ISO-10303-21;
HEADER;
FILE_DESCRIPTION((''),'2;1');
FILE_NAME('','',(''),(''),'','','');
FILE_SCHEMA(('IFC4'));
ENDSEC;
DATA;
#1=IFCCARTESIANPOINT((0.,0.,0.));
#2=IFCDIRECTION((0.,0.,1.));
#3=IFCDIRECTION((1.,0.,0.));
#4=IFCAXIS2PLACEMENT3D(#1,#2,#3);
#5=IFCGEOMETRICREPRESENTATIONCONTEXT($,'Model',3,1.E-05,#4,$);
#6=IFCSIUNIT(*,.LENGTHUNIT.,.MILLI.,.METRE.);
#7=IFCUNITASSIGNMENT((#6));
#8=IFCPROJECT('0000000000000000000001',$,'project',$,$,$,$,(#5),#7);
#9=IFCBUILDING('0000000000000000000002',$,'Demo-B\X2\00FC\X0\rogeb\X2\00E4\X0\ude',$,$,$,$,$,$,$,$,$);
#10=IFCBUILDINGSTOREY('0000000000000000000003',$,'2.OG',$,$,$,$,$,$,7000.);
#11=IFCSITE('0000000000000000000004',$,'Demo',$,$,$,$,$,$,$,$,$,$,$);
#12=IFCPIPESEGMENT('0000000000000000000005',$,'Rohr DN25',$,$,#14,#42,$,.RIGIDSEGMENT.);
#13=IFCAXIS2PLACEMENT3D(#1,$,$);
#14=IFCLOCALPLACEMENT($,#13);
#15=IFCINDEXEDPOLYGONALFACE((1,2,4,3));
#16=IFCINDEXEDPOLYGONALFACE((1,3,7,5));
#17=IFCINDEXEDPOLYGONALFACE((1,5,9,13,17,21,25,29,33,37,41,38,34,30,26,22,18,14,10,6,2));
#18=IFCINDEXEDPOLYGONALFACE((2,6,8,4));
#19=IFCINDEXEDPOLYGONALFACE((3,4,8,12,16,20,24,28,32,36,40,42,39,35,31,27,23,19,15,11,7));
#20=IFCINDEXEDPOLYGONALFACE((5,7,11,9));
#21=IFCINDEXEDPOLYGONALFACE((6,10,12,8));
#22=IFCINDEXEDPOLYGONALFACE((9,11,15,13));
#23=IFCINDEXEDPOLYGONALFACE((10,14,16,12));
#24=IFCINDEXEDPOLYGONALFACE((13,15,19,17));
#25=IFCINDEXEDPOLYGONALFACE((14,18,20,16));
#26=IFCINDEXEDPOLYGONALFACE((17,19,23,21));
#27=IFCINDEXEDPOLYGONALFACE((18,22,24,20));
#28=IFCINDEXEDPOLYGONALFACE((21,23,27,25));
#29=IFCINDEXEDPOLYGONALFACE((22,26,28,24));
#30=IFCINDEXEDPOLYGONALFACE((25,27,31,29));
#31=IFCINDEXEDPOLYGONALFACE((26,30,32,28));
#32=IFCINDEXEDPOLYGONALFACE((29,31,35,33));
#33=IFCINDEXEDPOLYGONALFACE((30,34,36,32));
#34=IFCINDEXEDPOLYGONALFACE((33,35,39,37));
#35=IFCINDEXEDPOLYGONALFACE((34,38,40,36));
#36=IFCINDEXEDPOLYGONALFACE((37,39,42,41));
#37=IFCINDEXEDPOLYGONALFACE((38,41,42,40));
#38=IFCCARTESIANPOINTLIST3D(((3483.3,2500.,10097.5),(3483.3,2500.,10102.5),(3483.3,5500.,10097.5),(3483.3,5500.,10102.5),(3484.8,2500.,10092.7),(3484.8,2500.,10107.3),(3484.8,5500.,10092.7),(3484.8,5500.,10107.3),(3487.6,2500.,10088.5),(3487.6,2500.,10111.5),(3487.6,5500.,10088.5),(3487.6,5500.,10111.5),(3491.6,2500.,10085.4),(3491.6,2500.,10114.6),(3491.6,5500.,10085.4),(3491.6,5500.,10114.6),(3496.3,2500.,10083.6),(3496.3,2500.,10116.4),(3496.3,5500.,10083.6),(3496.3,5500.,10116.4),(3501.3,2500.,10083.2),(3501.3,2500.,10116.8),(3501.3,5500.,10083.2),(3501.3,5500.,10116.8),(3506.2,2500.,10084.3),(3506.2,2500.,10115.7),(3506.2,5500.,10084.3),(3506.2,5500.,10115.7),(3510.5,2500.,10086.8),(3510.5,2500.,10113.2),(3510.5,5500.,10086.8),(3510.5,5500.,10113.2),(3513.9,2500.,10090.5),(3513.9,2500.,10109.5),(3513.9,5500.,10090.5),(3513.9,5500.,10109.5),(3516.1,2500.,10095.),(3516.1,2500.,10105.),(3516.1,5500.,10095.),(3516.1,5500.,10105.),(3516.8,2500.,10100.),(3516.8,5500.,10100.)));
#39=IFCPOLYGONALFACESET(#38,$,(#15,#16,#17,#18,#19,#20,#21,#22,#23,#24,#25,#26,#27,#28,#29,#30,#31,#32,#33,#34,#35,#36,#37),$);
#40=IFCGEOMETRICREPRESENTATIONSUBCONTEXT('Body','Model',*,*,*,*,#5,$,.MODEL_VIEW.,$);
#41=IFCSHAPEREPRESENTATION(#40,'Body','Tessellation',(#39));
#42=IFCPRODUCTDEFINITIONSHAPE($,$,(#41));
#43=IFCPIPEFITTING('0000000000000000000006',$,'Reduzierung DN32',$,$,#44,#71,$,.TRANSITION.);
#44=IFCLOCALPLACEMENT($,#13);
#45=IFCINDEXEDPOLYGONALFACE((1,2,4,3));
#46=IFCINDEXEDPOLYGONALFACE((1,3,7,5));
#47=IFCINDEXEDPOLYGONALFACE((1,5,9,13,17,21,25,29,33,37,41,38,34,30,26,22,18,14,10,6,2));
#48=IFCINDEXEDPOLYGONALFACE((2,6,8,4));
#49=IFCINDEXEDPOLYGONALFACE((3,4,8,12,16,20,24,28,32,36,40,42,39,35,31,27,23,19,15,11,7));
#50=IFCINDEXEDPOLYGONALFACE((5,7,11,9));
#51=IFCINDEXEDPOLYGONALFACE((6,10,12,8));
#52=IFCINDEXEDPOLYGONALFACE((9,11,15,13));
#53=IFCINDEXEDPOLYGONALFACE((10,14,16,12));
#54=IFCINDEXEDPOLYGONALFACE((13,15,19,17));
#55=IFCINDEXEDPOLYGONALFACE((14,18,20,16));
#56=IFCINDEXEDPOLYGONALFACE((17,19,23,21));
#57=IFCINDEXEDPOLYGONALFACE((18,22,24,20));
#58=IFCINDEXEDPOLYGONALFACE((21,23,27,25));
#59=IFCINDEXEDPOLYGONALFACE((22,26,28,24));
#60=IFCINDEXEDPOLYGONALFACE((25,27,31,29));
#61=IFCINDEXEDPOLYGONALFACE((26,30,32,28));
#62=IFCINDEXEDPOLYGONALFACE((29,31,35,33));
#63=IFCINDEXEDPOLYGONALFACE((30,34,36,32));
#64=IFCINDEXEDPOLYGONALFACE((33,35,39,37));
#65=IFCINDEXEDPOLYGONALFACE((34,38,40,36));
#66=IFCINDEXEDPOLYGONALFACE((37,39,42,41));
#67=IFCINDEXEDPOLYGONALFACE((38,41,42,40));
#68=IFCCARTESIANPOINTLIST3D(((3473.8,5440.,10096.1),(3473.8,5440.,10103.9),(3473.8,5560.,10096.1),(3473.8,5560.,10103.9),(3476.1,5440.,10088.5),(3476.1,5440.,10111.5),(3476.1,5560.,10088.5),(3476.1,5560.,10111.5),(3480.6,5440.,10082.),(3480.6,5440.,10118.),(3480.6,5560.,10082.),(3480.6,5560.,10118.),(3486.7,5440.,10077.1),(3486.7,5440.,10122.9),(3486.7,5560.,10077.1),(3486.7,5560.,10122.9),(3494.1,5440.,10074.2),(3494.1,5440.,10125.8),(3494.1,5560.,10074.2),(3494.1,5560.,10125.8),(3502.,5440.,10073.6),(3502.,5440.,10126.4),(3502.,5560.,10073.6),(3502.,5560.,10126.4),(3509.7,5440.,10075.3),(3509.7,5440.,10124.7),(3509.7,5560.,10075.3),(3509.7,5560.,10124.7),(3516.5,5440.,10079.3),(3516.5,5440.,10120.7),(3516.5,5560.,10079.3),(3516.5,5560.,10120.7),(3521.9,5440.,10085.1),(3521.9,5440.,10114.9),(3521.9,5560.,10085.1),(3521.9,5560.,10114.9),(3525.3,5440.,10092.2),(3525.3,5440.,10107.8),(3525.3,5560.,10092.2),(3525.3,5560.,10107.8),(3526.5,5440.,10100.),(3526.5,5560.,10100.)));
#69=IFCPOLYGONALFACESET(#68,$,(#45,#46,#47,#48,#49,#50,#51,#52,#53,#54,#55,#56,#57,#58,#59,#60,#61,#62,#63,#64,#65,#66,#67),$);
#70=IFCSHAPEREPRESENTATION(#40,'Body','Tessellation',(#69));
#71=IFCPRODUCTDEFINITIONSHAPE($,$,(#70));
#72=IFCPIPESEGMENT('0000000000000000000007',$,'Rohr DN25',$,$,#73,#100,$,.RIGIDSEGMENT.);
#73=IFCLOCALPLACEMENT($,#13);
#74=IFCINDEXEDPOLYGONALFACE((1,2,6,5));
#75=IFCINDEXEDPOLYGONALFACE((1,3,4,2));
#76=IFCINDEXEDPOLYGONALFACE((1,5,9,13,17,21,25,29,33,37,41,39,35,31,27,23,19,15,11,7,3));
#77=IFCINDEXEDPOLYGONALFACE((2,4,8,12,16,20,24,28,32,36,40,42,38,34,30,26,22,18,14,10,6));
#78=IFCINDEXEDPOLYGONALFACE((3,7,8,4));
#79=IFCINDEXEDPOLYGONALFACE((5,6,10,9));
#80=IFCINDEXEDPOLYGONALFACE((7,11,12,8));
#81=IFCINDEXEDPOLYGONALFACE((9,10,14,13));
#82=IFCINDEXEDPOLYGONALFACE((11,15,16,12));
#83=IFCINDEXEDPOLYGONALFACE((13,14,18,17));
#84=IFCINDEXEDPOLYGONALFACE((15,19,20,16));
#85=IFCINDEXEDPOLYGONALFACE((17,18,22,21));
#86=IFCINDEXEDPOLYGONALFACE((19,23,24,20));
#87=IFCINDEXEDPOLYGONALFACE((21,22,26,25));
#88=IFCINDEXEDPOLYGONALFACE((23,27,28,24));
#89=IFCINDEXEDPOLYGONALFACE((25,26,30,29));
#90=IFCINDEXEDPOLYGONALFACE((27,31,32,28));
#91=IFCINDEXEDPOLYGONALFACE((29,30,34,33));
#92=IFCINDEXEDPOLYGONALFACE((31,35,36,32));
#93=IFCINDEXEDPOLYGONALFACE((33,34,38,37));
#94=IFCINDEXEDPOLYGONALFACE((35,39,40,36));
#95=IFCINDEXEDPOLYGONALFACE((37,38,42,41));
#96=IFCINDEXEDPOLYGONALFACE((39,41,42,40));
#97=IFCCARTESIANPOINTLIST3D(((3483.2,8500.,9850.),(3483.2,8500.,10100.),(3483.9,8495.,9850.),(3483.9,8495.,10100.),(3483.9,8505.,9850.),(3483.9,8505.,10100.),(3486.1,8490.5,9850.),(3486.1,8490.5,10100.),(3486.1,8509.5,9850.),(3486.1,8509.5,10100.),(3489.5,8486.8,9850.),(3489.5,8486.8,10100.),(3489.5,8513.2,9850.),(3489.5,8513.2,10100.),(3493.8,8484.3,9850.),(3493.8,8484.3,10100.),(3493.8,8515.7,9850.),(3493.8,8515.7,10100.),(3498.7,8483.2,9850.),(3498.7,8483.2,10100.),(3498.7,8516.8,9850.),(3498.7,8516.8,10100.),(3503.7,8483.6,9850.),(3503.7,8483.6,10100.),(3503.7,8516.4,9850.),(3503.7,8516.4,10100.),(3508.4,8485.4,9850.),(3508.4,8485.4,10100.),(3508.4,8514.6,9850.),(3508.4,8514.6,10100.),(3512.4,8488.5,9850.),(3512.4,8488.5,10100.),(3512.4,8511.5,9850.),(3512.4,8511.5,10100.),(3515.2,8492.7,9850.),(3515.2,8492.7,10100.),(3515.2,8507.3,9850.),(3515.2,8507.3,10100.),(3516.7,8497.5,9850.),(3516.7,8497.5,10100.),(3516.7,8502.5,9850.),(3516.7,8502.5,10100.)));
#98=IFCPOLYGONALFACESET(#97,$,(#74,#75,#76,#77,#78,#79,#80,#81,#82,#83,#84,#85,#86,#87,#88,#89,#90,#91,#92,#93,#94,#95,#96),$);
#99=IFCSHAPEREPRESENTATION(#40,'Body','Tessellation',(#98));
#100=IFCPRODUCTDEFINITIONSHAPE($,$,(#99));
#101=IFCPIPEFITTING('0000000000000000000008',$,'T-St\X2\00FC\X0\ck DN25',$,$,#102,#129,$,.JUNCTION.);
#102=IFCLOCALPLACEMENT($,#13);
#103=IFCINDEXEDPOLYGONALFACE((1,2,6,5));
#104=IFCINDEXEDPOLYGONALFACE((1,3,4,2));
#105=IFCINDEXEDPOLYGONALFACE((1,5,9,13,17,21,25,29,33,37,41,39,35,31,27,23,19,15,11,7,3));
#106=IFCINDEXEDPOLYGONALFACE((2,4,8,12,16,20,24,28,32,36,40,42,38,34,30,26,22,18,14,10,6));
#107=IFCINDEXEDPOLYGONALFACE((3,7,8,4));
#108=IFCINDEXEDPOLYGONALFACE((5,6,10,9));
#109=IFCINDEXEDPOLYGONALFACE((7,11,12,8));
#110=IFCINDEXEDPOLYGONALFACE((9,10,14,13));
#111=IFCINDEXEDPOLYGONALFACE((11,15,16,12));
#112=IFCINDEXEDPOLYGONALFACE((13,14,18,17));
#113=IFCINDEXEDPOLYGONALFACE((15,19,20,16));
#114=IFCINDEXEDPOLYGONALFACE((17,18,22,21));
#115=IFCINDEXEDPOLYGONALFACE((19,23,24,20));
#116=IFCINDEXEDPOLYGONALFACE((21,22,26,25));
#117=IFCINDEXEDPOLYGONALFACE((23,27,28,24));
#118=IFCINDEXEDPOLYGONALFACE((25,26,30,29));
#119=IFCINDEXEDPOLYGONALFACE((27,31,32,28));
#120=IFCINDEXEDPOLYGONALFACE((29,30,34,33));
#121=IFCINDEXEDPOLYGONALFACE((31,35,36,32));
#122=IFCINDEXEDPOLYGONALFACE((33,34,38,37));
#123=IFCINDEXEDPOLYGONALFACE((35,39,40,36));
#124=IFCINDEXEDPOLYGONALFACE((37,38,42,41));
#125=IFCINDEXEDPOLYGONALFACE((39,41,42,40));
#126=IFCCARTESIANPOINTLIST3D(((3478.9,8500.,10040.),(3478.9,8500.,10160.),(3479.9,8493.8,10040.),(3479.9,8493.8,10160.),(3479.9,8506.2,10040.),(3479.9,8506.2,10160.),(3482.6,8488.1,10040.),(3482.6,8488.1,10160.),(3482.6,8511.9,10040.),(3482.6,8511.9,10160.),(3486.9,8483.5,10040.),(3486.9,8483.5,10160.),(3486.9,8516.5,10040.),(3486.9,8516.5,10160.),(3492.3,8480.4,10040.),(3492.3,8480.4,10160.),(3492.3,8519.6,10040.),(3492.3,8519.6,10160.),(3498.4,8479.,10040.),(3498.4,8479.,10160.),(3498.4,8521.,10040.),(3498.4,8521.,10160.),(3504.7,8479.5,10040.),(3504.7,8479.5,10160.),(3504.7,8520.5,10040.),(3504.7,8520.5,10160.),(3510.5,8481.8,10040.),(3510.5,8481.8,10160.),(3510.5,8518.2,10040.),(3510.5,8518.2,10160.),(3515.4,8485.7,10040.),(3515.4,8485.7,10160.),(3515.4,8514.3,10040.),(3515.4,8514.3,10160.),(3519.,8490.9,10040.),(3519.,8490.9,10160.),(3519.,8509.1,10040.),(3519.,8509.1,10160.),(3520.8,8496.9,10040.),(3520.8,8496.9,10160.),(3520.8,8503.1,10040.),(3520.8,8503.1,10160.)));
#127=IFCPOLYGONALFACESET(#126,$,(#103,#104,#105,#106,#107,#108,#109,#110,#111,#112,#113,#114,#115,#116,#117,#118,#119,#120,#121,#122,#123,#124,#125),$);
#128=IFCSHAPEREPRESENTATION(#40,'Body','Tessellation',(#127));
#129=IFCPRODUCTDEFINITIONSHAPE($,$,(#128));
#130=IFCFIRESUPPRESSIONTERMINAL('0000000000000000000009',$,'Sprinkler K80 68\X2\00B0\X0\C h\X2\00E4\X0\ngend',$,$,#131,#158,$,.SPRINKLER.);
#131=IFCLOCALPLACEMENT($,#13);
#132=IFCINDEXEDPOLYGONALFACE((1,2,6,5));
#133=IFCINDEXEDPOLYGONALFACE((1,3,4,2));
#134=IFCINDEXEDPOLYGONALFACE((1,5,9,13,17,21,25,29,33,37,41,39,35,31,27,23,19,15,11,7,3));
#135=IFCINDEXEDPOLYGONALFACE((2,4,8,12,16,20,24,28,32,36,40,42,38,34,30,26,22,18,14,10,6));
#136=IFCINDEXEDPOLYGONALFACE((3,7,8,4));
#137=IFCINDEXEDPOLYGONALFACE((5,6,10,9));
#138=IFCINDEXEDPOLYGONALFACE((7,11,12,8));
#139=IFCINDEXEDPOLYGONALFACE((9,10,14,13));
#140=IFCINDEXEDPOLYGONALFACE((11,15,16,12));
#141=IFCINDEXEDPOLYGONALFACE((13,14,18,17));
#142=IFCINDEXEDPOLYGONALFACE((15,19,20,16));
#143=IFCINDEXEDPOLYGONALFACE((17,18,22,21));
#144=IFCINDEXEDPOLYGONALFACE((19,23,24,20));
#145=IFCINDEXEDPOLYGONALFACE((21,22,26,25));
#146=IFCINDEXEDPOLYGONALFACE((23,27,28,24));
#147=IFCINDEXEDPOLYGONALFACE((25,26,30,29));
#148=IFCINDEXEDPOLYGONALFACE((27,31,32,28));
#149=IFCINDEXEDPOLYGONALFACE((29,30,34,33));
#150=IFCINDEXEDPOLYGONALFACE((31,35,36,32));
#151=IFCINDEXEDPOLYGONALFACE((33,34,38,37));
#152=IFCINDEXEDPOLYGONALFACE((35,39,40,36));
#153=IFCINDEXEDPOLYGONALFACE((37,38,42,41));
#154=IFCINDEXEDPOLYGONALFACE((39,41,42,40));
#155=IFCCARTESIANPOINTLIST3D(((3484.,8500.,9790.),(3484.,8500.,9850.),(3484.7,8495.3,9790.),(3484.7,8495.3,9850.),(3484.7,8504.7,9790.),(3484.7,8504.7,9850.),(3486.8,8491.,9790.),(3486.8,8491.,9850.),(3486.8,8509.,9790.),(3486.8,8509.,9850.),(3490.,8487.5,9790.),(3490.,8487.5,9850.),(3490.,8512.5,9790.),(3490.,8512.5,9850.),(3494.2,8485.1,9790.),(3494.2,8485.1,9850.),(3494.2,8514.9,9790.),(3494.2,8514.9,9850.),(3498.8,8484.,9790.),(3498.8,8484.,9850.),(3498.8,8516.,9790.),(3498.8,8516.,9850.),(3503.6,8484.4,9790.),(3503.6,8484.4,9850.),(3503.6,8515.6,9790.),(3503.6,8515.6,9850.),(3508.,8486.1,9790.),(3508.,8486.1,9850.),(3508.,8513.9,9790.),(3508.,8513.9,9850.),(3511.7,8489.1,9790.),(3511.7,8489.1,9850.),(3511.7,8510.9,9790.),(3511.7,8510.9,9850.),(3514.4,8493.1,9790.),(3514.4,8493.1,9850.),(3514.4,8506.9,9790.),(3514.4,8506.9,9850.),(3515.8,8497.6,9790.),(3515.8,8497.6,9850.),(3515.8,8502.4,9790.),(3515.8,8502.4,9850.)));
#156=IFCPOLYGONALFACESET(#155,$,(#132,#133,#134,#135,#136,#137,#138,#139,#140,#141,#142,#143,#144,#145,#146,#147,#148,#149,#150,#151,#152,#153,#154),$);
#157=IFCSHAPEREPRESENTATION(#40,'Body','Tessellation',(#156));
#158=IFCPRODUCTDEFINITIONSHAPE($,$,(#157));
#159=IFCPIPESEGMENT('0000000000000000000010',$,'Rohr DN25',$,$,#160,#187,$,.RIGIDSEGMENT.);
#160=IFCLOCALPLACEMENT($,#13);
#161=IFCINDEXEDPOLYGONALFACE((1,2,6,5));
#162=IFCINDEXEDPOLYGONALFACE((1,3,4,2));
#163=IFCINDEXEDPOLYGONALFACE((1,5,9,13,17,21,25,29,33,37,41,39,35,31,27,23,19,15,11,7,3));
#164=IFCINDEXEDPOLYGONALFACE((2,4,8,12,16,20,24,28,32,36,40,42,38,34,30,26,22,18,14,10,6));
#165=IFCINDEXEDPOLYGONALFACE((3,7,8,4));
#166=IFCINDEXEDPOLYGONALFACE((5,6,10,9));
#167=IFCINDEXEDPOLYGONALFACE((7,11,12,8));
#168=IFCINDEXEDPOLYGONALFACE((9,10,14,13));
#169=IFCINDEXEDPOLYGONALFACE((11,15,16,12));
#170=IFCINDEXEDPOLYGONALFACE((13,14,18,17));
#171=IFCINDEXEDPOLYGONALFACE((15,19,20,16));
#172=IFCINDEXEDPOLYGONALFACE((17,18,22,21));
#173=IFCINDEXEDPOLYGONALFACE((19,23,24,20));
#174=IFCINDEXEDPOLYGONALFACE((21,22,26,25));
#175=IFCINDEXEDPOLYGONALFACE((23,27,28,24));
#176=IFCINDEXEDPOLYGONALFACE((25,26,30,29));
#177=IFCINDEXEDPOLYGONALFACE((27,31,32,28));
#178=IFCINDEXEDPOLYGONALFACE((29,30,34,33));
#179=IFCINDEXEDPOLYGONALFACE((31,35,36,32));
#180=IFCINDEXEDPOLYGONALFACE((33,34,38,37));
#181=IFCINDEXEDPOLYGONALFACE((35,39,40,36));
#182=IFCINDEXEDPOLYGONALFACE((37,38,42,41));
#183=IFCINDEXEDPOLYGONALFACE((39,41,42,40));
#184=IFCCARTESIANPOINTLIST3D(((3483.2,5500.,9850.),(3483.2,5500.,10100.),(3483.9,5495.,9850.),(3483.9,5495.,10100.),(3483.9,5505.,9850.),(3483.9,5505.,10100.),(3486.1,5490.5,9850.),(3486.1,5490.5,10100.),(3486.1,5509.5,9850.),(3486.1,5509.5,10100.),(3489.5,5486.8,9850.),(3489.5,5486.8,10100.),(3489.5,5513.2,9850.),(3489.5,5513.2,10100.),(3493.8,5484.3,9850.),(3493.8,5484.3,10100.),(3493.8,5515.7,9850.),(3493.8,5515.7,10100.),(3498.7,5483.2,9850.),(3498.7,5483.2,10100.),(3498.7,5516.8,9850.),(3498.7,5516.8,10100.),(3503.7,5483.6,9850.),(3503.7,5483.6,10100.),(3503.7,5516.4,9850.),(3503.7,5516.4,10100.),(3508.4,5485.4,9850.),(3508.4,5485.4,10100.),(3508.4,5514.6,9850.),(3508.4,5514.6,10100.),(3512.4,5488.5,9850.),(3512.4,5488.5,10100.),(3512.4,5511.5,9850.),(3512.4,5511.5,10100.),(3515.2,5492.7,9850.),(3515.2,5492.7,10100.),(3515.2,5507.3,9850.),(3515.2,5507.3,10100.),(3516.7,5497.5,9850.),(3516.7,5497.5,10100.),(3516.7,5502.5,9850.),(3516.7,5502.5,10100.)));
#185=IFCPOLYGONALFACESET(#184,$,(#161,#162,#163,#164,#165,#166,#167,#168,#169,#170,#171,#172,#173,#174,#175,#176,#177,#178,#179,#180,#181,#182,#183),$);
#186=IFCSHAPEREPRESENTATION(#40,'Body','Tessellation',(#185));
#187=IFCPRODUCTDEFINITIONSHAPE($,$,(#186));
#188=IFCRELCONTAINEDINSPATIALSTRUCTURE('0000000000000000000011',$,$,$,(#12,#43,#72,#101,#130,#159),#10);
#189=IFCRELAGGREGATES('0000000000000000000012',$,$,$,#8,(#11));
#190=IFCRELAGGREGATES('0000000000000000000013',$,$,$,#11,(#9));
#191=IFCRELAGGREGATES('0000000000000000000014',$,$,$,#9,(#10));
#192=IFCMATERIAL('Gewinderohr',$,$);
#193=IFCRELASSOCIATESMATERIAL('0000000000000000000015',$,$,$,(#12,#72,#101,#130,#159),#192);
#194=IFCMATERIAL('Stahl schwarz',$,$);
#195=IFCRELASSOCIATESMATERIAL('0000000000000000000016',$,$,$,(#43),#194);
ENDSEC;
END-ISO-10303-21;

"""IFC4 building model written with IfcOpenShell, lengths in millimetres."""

from ifc_helpers import new_model, si_unit, frame, origin_with_axes, place, context, subcontext, project, spatial, circle, extrude, material, element, save


model = new_model("IFC4")

# Units and contexts
model_context = context("Model", 3, precision=1e-05, world=origin_with_axes())
body_context = subcontext(model_context, "Body", "Model", "MODEL_VIEW")
ifc_project = project(units=[si_unit("LENGTHUNIT", "METRE", prefix="MILLI")], contexts=[model_context])

# Site, building, storey
site = spatial("IfcSite", under=ifc_project, Name="Demo")
building = spatial("IfcBuilding", under=site, Name="Demo-Bürogebäude")
storey = spatial("IfcBuildingStorey", under=building, Name="2.OG", Elevation=7000.0)

# Shared definitions
ifc_material_1 = material(Name="Stahl schwarz")

# Pipe segment
ifc_material_2 = material(Name="Gewinderohr")
pipe_segment_1_placement = place(None, frame((3500.0, 5500.0, 10100.0), z_axis=(0.0, -1.0, 0.0), x_axis=(1.0, 0.0, 0.0)))
element("IfcPipeSegment", 1, at=pipe_segment_1_placement, inside=storey, material=ifc_material_2, Name="Rohr DN25", PredefinedType="RIGIDSEGMENT", context=body_context, shape_type="SweptSolid", body=[
    extrude(circle(Radius=16.9), origin_with_axes(), (0.0, 0.0, 1.0), 3000.0),
])

# Pipe fitting
pipe_fitting_1_placement = place(None, frame((3500.0, 5560.0, 10100.0), z_axis=(0.0, -1.0, 0.0), x_axis=(1.0, 0.0, 0.0)))
element("IfcPipeFitting", 2, at=pipe_fitting_1_placement, inside=storey, material=ifc_material_1, Name="Reduzierung DN32", PredefinedType="TRANSITION", context=body_context, shape_type="SweptSolid", body=[
    extrude(circle(Radius=26.5), origin_with_axes(), (0.0, 0.0, 1.0), 120.0),
])

# Pipe segment
pipe_segment_2_placement = place(None, frame((3500.0, 8500.0, 10100.0), z_axis=(0.0, 0.0, -1.0), x_axis=(-1.0, 0.0, 0.0)))
element("IfcPipeSegment", 3, at=pipe_segment_2_placement, inside=storey, material=ifc_material_2, Name="Rohr DN25", PredefinedType="RIGIDSEGMENT", context=body_context, shape_type="SweptSolid", body=[
    extrude(circle(Radius=16.9), origin_with_axes(), (0.0, 0.0, 1.0), 250.0),
])

# Pipe fitting
pipe_fitting_2_placement = place(None, frame((3500.0, 8500.0, 10160.0), z_axis=(0.0, 0.0, -1.0), x_axis=(-1.0, 0.0, 0.0)))
element("IfcPipeFitting", 4, at=pipe_fitting_2_placement, inside=storey, material=ifc_material_2, Name="T-Stück DN25", PredefinedType="JUNCTION", context=body_context, shape_type="SweptSolid", body=[
    extrude(circle(Radius=21.1), origin_with_axes(), (0.0, 0.0, 1.0), 120.0),
])

# Fire suppression terminal
fire_suppression_terminal_1_placement = place(None, frame((3500.0, 8500.0, 9850.0), z_axis=(0.0, 0.0, -1.0), x_axis=(-1.0, 0.0, 0.0)))
element("IfcFireSuppressionTerminal", 5, at=fire_suppression_terminal_1_placement, inside=storey, material=ifc_material_2, Name="Sprinkler K80 68°C hängend", PredefinedType="SPRINKLER", context=body_context, shape_type="SweptSolid", body=[
    extrude(circle(Radius=16.0), origin_with_axes(), (0.0, 0.0, 1.0), 60.0),
])

# Pipe segment
pipe_segment_3_placement = place(None, frame((3500.0, 5500.0, 10100.0), z_axis=(0.0, 0.0, -1.0), x_axis=(-1.0, 0.0, 0.0)))
element("IfcPipeSegment", 6, at=pipe_segment_3_placement, inside=storey, material=ifc_material_2, Name="Rohr DN25", PredefinedType="RIGIDSEGMENT", context=body_context, shape_type="SweptSolid", body=[
    extrude(circle(Radius=16.9), origin_with_axes(), (0.0, 0.0, 1.0), 250.0),
])

save(model, "model.ifc")
